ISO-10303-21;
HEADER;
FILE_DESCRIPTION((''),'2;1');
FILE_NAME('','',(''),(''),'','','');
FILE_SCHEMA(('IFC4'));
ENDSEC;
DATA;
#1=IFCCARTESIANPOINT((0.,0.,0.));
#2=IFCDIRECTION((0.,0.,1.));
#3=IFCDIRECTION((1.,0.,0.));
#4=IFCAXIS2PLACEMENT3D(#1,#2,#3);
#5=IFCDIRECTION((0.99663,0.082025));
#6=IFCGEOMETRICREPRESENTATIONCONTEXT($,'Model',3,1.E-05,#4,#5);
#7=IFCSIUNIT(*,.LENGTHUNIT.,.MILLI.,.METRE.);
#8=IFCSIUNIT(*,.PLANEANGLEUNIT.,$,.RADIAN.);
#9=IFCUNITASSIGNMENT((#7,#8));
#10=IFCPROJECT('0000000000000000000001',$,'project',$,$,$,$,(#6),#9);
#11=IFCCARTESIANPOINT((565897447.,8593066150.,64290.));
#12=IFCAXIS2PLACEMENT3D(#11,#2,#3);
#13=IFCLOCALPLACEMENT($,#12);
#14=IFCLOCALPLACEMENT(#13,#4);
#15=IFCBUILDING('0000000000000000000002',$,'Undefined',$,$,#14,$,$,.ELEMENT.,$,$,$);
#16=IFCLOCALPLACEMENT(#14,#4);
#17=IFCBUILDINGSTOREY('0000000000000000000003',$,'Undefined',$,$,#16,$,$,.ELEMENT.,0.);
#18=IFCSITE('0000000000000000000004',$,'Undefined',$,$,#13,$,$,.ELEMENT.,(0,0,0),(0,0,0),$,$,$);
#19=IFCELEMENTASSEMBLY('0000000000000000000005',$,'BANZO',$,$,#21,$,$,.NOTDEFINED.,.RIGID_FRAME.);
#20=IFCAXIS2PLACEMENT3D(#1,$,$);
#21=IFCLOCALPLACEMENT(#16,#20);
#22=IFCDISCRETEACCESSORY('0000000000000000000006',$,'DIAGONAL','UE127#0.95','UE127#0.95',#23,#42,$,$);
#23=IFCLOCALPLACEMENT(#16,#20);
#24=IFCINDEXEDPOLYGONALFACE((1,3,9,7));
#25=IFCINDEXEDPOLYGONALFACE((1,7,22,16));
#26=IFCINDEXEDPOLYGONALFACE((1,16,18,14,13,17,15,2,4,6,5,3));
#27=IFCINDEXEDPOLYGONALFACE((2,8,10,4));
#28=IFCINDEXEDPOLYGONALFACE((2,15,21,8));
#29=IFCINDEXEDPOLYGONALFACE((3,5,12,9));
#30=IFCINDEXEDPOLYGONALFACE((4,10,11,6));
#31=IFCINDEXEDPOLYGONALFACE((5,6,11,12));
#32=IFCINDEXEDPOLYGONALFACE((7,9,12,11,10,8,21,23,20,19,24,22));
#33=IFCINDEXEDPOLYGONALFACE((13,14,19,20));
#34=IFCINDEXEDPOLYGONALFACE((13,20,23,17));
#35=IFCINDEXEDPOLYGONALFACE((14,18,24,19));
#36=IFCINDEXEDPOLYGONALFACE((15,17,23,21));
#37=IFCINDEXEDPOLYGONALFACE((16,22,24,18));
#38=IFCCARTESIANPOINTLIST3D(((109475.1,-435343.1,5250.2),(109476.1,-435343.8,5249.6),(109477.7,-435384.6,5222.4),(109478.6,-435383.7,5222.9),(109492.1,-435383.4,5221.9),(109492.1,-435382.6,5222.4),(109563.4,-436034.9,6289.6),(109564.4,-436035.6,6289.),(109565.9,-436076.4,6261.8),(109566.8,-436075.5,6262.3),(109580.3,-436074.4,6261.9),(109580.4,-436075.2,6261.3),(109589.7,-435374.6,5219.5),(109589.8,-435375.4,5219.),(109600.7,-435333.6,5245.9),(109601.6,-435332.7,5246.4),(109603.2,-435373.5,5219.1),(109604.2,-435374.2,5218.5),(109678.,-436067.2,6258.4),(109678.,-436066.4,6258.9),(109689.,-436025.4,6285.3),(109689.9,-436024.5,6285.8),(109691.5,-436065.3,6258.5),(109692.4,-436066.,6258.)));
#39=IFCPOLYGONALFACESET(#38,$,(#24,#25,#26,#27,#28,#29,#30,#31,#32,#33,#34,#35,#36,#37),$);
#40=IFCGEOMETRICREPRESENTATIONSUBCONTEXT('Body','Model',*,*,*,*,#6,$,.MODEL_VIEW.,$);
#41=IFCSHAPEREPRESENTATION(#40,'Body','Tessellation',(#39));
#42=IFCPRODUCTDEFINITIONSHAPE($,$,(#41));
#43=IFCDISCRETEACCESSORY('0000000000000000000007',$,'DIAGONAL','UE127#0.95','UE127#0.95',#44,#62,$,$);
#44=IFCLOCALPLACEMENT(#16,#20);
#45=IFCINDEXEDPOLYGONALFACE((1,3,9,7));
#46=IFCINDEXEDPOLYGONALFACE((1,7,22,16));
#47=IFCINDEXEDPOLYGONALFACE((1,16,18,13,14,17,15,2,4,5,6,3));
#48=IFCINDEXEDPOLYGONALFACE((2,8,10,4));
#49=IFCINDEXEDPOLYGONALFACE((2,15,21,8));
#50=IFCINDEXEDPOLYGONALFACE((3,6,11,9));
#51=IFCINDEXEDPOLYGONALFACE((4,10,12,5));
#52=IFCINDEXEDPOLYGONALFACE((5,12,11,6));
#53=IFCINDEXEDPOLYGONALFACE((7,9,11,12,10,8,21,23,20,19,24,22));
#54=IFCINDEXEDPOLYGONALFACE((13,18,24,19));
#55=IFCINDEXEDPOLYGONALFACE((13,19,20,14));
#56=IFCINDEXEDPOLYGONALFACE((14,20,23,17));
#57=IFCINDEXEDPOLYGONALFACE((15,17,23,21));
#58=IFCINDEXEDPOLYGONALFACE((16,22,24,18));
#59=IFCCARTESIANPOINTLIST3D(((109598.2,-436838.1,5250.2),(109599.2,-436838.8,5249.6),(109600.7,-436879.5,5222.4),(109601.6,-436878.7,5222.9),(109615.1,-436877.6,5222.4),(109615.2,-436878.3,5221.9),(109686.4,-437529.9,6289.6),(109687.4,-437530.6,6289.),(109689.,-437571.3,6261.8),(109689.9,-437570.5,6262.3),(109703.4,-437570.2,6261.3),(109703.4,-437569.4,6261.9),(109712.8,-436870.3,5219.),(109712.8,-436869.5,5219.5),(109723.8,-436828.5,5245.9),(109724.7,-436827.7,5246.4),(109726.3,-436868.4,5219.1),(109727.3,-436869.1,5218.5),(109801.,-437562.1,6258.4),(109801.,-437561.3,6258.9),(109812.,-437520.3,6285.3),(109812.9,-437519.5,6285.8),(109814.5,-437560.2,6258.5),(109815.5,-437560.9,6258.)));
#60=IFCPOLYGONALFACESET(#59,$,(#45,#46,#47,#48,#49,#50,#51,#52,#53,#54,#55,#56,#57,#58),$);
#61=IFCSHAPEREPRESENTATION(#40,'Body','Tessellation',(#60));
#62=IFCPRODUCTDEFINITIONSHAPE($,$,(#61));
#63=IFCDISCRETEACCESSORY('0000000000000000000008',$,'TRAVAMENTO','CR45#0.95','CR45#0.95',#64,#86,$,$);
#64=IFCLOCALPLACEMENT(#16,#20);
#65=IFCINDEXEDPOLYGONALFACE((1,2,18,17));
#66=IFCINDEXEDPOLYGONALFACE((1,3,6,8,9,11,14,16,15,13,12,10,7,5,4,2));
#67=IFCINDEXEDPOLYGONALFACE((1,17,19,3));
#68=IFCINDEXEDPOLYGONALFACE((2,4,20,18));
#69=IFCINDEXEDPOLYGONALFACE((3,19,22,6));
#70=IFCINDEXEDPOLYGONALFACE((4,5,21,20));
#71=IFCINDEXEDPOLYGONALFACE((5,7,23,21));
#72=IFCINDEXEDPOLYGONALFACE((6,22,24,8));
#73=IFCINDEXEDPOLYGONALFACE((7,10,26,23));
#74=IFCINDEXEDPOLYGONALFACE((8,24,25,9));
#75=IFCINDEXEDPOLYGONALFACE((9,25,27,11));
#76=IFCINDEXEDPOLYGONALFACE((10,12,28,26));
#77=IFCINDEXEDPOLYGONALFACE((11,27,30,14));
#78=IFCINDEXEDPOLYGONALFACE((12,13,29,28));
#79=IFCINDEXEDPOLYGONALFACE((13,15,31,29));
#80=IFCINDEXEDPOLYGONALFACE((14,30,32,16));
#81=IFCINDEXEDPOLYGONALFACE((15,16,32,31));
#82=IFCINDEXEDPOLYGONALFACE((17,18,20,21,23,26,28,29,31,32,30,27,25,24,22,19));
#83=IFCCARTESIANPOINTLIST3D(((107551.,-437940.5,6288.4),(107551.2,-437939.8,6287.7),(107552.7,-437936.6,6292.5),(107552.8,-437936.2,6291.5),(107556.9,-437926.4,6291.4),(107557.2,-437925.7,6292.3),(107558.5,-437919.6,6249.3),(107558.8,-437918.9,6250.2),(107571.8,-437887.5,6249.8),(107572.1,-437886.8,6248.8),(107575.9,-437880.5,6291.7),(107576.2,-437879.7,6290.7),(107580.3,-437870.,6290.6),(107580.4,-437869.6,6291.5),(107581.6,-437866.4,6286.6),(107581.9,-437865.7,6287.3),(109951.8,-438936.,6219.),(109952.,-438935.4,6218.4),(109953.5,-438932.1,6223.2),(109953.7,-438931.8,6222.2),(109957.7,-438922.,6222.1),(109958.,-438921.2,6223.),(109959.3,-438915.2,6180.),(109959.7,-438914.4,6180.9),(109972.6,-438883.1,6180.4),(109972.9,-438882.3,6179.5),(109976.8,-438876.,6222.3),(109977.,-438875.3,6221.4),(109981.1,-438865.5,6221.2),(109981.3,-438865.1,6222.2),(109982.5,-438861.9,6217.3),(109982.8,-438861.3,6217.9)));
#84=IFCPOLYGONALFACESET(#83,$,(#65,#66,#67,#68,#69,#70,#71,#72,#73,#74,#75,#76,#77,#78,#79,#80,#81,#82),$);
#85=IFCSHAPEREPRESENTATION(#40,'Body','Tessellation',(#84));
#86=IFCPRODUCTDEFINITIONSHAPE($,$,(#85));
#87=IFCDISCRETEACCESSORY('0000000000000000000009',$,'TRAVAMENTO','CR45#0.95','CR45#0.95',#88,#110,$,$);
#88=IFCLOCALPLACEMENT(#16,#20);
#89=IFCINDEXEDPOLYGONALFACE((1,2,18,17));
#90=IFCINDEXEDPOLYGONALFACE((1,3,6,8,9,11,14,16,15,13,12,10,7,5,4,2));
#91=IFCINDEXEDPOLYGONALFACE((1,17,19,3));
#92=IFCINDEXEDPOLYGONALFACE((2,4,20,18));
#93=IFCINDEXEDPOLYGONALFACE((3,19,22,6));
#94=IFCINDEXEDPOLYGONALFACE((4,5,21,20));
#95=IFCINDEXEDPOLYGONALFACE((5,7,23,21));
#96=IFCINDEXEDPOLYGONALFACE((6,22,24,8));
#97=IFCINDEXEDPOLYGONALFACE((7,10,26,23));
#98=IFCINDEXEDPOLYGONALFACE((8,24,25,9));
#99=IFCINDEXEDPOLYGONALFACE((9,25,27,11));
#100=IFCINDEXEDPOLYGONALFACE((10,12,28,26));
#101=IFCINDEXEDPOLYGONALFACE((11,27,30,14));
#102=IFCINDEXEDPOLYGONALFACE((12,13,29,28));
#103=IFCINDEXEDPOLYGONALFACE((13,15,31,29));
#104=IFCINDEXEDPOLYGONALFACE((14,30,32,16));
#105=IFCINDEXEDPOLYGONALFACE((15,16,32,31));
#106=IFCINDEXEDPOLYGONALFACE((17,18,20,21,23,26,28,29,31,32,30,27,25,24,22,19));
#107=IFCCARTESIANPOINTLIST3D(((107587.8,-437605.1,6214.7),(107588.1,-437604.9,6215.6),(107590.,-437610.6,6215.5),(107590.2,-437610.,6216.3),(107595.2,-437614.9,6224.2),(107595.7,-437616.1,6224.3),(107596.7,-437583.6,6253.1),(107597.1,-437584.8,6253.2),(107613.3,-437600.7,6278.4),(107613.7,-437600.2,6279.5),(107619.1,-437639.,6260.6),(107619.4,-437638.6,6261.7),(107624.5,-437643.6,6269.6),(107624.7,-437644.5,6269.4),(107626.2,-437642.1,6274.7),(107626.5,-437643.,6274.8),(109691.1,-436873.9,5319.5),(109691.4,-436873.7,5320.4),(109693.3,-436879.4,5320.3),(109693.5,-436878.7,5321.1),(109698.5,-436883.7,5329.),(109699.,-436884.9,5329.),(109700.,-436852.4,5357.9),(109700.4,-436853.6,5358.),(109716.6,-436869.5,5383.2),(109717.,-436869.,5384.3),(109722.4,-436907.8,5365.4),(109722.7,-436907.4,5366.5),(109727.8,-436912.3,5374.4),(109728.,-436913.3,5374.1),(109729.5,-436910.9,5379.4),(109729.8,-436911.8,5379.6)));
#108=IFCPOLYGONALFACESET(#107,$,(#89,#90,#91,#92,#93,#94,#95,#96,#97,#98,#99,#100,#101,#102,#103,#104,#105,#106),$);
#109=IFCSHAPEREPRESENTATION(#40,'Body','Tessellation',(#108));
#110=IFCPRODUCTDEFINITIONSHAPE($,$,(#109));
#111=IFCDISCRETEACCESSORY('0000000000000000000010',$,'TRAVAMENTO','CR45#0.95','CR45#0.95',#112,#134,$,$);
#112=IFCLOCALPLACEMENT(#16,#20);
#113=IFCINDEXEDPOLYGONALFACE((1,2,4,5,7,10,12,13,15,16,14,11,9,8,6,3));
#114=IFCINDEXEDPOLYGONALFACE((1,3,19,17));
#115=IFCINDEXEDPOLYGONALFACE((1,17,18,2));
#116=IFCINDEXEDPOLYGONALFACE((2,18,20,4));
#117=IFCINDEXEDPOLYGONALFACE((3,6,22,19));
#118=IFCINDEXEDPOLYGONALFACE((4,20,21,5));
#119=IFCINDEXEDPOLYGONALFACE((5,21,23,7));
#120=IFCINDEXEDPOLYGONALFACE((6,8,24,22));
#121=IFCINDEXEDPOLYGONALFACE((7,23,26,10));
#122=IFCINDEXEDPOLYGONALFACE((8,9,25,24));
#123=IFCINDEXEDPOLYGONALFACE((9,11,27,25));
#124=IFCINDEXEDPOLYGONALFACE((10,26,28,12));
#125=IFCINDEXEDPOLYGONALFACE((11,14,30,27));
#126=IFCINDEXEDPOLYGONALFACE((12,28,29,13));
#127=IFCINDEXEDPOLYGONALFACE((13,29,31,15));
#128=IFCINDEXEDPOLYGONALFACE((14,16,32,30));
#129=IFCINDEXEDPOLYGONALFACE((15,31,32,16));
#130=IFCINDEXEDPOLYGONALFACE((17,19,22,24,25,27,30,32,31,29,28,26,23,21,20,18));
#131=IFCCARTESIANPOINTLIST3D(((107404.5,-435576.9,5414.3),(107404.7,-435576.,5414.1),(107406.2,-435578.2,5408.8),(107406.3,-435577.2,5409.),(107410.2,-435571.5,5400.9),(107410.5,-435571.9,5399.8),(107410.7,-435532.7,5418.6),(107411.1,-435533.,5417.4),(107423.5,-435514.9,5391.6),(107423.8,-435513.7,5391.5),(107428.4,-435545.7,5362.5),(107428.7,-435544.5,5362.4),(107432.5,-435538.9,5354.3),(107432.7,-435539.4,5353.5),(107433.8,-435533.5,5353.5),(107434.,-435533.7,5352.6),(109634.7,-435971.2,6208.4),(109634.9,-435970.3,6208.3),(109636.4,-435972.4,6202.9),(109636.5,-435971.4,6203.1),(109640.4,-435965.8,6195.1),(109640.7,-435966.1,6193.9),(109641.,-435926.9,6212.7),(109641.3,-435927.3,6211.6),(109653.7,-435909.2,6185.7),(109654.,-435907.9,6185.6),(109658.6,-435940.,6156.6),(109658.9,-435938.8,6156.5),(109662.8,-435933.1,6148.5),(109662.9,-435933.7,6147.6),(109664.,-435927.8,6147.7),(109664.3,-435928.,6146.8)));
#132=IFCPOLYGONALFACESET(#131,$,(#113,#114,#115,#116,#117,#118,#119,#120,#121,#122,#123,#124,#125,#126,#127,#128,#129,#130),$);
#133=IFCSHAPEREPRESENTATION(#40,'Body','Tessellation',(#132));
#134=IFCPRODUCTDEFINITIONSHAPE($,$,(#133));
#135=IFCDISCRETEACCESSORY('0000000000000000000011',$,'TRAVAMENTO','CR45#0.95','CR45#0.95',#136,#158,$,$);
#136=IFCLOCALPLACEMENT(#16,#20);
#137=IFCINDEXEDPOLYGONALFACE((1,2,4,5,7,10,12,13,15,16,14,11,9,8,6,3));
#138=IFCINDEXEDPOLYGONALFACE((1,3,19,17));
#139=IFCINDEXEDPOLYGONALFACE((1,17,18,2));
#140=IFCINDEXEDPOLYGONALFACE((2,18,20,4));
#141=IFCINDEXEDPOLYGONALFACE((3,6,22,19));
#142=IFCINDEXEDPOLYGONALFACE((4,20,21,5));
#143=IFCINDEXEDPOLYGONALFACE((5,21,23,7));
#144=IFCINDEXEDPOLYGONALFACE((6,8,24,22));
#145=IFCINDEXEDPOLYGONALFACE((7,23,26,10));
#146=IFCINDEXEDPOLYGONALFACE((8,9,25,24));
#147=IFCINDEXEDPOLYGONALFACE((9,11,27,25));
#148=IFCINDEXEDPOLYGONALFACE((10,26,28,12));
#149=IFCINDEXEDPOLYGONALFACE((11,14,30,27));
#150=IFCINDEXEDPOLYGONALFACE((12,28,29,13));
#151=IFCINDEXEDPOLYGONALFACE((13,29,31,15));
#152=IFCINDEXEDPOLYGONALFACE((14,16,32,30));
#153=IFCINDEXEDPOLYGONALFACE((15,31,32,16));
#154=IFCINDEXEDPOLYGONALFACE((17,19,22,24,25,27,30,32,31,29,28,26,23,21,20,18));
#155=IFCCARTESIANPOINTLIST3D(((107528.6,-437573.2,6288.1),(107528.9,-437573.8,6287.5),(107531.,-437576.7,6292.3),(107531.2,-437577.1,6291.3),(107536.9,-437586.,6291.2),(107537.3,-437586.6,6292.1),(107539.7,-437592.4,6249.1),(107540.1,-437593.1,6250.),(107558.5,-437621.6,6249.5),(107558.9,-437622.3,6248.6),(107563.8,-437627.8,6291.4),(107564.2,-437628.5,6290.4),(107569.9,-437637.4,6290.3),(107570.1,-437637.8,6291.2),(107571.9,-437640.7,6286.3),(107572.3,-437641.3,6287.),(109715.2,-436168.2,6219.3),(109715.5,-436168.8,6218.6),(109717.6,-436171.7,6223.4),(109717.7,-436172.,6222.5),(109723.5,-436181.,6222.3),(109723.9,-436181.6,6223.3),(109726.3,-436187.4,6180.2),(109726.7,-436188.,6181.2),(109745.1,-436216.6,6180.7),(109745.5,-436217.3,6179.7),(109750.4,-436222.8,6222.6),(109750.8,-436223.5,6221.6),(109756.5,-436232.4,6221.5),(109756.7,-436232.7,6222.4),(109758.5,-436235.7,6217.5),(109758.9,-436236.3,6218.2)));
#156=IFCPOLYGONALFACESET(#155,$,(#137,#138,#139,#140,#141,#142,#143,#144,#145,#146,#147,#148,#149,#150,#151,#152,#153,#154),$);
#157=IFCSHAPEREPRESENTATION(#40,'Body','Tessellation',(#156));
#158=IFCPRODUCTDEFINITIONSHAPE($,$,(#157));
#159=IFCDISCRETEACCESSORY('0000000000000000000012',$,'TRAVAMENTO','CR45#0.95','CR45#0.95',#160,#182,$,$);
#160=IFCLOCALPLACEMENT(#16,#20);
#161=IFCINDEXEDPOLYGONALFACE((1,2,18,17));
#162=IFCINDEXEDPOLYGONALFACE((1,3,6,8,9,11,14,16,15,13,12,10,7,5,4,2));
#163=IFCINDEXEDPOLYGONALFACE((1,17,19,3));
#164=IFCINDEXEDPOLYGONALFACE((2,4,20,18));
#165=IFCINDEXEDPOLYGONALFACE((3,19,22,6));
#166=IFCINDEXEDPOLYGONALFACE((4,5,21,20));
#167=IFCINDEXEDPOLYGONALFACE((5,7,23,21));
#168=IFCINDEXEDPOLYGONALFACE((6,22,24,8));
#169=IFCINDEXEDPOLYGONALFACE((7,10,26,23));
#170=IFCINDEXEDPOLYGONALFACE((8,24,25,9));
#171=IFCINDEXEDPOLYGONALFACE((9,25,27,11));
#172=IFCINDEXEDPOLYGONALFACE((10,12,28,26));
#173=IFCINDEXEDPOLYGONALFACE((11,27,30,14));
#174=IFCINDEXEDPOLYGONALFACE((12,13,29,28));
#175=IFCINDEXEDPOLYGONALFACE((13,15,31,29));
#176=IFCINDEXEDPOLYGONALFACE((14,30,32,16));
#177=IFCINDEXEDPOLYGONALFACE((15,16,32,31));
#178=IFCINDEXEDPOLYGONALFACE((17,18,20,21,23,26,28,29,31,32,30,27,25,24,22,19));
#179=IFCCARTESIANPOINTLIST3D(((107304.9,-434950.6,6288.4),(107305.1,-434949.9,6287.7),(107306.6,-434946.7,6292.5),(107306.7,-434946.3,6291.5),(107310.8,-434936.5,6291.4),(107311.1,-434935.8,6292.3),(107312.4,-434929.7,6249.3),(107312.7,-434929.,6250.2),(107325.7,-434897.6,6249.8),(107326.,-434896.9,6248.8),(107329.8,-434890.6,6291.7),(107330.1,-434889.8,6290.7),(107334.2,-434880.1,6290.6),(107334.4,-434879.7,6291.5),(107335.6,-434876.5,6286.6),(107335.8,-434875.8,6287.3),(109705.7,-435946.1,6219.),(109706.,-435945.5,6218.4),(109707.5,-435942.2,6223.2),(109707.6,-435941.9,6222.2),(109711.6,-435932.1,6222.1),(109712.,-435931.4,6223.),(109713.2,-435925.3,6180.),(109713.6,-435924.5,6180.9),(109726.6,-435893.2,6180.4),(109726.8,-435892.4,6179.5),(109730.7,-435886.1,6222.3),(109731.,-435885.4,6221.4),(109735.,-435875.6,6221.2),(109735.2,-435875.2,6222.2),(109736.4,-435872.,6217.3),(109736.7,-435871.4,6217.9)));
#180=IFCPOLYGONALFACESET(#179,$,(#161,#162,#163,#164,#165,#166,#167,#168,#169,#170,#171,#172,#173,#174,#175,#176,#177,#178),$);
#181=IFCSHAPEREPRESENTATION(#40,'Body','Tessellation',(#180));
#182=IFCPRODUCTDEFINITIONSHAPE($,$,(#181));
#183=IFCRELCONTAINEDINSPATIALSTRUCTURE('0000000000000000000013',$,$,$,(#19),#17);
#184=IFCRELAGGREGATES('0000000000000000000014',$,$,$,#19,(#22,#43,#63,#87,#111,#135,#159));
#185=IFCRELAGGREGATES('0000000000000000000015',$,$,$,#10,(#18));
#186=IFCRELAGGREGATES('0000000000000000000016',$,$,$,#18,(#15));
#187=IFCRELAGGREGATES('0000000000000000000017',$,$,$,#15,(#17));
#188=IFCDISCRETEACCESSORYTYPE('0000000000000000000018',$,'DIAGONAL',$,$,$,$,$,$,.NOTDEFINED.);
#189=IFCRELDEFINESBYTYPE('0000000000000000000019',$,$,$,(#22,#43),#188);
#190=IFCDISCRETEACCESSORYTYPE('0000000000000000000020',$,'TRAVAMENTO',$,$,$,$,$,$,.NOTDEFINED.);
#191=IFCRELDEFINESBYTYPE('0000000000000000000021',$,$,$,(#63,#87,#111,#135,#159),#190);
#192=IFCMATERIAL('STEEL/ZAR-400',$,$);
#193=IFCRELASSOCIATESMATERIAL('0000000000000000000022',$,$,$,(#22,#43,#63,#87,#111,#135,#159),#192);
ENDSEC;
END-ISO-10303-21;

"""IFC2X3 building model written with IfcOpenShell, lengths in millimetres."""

from ifc_helpers import new_model, si_unit, direction, frame, frame_2d, origin_with_axes, place, context, subcontext, project, spatial, polyline, c_section, outline, extrude, material, type_object, element, aggregate, save


model = new_model("IFC2X3")

# Units and contexts
model_context = context("Model", 3, precision=1e-05, world=origin_with_axes(), true_north=direction((0.99663, 0.082025)))
body_context = subcontext(model_context, "Body", "Model", "MODEL_VIEW")
ifc_project = project(units=[si_unit("LENGTHUNIT", "METRE", prefix="MILLI"), si_unit("PLANEANGLEUNIT", "RADIAN")], contexts=[model_context])

# Site, building, storey
site_placement = place(None, frame((565897447.0, 8593066150.0, 64290.0), z_axis=(0.0, 0.0, 1.0), x_axis=(1.0, 0.0, 0.0)))
site = spatial("IfcSite", under=ifc_project, at=site_placement, Name="Undefined", CompositionType="ELEMENT", RefLatitude=(0, 0, 0), RefLongitude=(0, 0, 0))
building_placement = place(site_placement, origin_with_axes())
building = spatial("IfcBuilding", under=site, at=building_placement, Name="Undefined", CompositionType="ELEMENT")
storey_placement = place(building_placement, origin_with_axes())
storey = spatial("IfcBuildingStorey", under=building, at=storey_placement, Name="Undefined", CompositionType="ELEMENT", Elevation=0.0)

# Element assembly, discrete accessories
assembly_placement = place(storey_placement, origin_with_axes())
assembly = element("IfcElementAssembly", 1, at=assembly_placement, inside=storey, Name="BANZO", AssemblyPlace="NOTDEFINED", PredefinedType="RIGID_FRAME")
ifc_material_1 = material(Name="STEEL/ZAR-400")
discrete_accessory_type_1 = type_object("IfcDiscreteAccessoryType", Name="DIAGONAL")
discrete_accessory_1_placement = place(assembly_placement, frame((109627.9, -436050.5, 6273.8), z_axis=(0.996182, 0.081989, -0.029987), x_axis=(-0.070485, 0.552697, -0.830396)))
discrete_accessory_1 = element("IfcDiscreteAccessory", 2, at=discrete_accessory_1_placement, type_object=discrete_accessory_type_1, material=ifc_material_1, Name="DIAGONAL", Description="UE127#0.95", ObjectType="UE127#0.95", context=body_context, shape_type="SweptSolid", body=[
    extrude(c_section(Depth=127.0, Width=50.0, WallThickness=0.9, Girth=14.5, at=frame_2d((0.0, 0.0), x_axis=(1.0, 0.0))), frame((1251.7, 0.0, 0.0), z_axis=(-1.0, 0.0, 0.0), x_axis=(0.0, -1.0, 0.0)), (0.0, 0.0, 1.0), 1251.7),
])
discrete_accessory_2_placement = place(assembly_placement, frame((109750.9, -437545.4, 6273.8), z_axis=(0.996182, 0.081989, -0.029987), x_axis=(-0.070485, 0.552697, -0.830396)))
discrete_accessory_2 = element("IfcDiscreteAccessory", 3, at=discrete_accessory_2_placement, type_object=discrete_accessory_type_1, material=ifc_material_1, Name="DIAGONAL", Description="UE127#0.95", ObjectType="UE127#0.95", context=body_context, shape_type="SweptSolid", body=[
    extrude(c_section(Depth=127.0, Width=50.0, WallThickness=0.9, Girth=14.5, at=frame_2d((0.0, 0.0), x_axis=(1.0, 0.0))), frame((1251.7, 0.0, 0.0), z_axis=(-1.0, 0.0, 0.0), x_axis=(0.0, -1.0, 0.0)), (0.0, 0.0, 1.0), 1251.7),
])
discrete_accessory_type_2 = type_object("IfcDiscreteAccessoryType", Name="TRAVAMENTO")
discrete_accessory_3_placement = place(assembly_placement, frame((107565.8, -437903.4, 6270.5), z_axis=(-0.029887, -0.002459, -0.99955), x_axis=(0.923403, -0.382903, -0.026668)))
discrete_accessory_3 = element("IfcDiscreteAccessory", 4, at=discrete_accessory_3_placement, type_object=discrete_accessory_type_2, material=ifc_material_1, Name="TRAVAMENTO", Description="CR45#0.95", ObjectType="CR45#0.95", context=body_context, shape_type="SweptSolid", body=[
    extrude(outline(polyline([(-35.5, -20.5), (-24.9, -20.5), (-17.4, 21.5), (18.1, 21.5), (25.6, -20.5), (36.2, -20.5), (40.1, -16.6), (40.8, -17.3), (36.6, -21.5), (24.8, -21.5), (17.3, 20.5), (-16.6, 20.5), (-24.1, -21.5), (-35.9, -21.5), (-40.1, -17.3), (-39.4, -16.6), (-35.5, -20.5)])), frame((2600.0, 0.0, 0.0), z_axis=(-1.0, 0.0, 0.0), x_axis=(0.0, -1.0, 0.0)), (0.0, 0.0, 1.0), 2600.0),
])
discrete_accessory_4_placement = place(assembly_placement, frame((109709.7, -436878.7, 5359.4), z_axis=(-0.05151, 0.82934, 0.556366), x_axis=(-0.876377, -0.30467, 0.373015)))
discrete_accessory_4 = element("IfcDiscreteAccessory", 5, at=discrete_accessory_4_placement, type_object=discrete_accessory_type_2, material=ifc_material_1, Name="TRAVAMENTO", Description="CR45#0.95", ObjectType="CR45#0.95", context=body_context, shape_type="SweptSolid", body=[
    extrude(outline(polyline([(-35.5, -20.5), (-24.9, -20.5), (-17.4, 21.5), (18.1, 21.5), (25.6, -20.5), (36.2, -20.5), (40.1, -16.6), (40.8, -17.3), (36.6, -21.5), (24.8, -21.5), (17.3, 20.5), (-16.6, 20.5), (-24.1, -21.5), (-35.9, -21.5), (-40.1, -17.3), (-39.4, -16.6), (-35.5, -20.5)])), frame((2400.0, 0.0, 0.0), z_axis=(-1.0, 0.0, 0.0), x_axis=(0.0, -1.0, 0.0)), (0.0, 0.0, 1.0), 2400.0),
])
discrete_accessory_5_placement = place(assembly_placement, frame((107418.5, -435540.8, 5392.8), z_axis=(-0.05151, 0.82934, 0.556366), x_axis=(0.929259, -0.164269, 0.330898)))
discrete_accessory_5 = element("IfcDiscreteAccessory", 6, at=discrete_accessory_5_placement, type_object=discrete_accessory_type_2, material=ifc_material_1, Name="TRAVAMENTO", Description="CR45#0.95", ObjectType="CR45#0.95", context=body_context, shape_type="SweptSolid", body=[
    extrude(outline(polyline([(-35.5, -20.5), (-24.9, -20.5), (-17.4, 21.5), (18.1, 21.5), (25.6, -20.5), (36.2, -20.5), (40.1, -16.6), (40.8, -17.3), (36.6, -21.5), (24.8, -21.5), (17.3, 20.5), (-16.6, 20.5), (-24.1, -21.5), (-35.9, -21.5), (-40.1, -17.3), (-39.4, -16.6), (-35.5, -20.5)])), frame((2400.0, 0.0, 0.0), z_axis=(-1.0, 0.0, 0.0), x_axis=(0.0, -1.0, 0.0)), (0.0, 0.0, 1.0), 2400.0),
])
discrete_accessory_6_placement = place(assembly_placement, frame((109736.3, -436202.0, 6201.4), z_axis=(-0.029886, -0.00246, -0.99955), x_axis=(-0.840995, -0.540395, 0.026476)))
discrete_accessory_6 = element("IfcDiscreteAccessory", 7, at=discrete_accessory_6_placement, type_object=discrete_accessory_type_2, material=ifc_material_1, Name="TRAVAMENTO", Description="CR45#0.95", ObjectType="CR45#0.95", context=body_context, shape_type="SweptSolid", body=[
    extrude(outline(polyline([(-35.5, -20.5), (-24.9, -20.5), (-17.4, 21.5), (18.1, 21.5), (25.6, -20.5), (36.2, -20.5), (40.1, -16.6), (40.8, -17.3), (36.6, -21.5), (24.8, -21.5), (17.3, 20.5), (-16.6, 20.5), (-24.1, -21.5), (-35.9, -21.5), (-40.1, -17.3), (-39.4, -16.6), (-35.5, -20.5)])), frame((2600.0, 0.0, 0.0), z_axis=(-1.0, 0.0, 0.0), x_axis=(0.0, -1.0, 0.0)), (0.0, 0.0, 1.0), 2600.0),
])
discrete_accessory_7_placement = place(assembly_placement, frame((107319.7, -434913.6, 6270.5), z_axis=(-0.029887, -0.002459, -0.99955), x_axis=(0.923403, -0.382903, -0.026668)))
discrete_accessory_7 = element("IfcDiscreteAccessory", 8, at=discrete_accessory_7_placement, type_object=discrete_accessory_type_2, material=ifc_material_1, Name="TRAVAMENTO", Description="CR45#0.95", ObjectType="CR45#0.95", context=body_context, shape_type="SweptSolid", body=[
    extrude(outline(polyline([(-35.5, -20.5), (-24.9, -20.5), (-17.4, 21.5), (18.1, 21.5), (25.6, -20.5), (36.2, -20.5), (40.1, -16.6), (40.8, -17.3), (36.6, -21.5), (24.8, -21.5), (17.3, 20.5), (-16.6, 20.5), (-24.1, -21.5), (-35.9, -21.5), (-40.1, -17.3), (-39.4, -16.6), (-35.5, -20.5)])), frame((2600.0, 0.0, 0.0), z_axis=(-1.0, 0.0, 0.0), x_axis=(0.0, -1.0, 0.0)), (0.0, 0.0, 1.0), 2600.0),
])
aggregate(assembly, [discrete_accessory_1, discrete_accessory_2, discrete_accessory_3, discrete_accessory_4, discrete_accessory_5, discrete_accessory_6, discrete_accessory_7])

save(model, "model.ifc")
